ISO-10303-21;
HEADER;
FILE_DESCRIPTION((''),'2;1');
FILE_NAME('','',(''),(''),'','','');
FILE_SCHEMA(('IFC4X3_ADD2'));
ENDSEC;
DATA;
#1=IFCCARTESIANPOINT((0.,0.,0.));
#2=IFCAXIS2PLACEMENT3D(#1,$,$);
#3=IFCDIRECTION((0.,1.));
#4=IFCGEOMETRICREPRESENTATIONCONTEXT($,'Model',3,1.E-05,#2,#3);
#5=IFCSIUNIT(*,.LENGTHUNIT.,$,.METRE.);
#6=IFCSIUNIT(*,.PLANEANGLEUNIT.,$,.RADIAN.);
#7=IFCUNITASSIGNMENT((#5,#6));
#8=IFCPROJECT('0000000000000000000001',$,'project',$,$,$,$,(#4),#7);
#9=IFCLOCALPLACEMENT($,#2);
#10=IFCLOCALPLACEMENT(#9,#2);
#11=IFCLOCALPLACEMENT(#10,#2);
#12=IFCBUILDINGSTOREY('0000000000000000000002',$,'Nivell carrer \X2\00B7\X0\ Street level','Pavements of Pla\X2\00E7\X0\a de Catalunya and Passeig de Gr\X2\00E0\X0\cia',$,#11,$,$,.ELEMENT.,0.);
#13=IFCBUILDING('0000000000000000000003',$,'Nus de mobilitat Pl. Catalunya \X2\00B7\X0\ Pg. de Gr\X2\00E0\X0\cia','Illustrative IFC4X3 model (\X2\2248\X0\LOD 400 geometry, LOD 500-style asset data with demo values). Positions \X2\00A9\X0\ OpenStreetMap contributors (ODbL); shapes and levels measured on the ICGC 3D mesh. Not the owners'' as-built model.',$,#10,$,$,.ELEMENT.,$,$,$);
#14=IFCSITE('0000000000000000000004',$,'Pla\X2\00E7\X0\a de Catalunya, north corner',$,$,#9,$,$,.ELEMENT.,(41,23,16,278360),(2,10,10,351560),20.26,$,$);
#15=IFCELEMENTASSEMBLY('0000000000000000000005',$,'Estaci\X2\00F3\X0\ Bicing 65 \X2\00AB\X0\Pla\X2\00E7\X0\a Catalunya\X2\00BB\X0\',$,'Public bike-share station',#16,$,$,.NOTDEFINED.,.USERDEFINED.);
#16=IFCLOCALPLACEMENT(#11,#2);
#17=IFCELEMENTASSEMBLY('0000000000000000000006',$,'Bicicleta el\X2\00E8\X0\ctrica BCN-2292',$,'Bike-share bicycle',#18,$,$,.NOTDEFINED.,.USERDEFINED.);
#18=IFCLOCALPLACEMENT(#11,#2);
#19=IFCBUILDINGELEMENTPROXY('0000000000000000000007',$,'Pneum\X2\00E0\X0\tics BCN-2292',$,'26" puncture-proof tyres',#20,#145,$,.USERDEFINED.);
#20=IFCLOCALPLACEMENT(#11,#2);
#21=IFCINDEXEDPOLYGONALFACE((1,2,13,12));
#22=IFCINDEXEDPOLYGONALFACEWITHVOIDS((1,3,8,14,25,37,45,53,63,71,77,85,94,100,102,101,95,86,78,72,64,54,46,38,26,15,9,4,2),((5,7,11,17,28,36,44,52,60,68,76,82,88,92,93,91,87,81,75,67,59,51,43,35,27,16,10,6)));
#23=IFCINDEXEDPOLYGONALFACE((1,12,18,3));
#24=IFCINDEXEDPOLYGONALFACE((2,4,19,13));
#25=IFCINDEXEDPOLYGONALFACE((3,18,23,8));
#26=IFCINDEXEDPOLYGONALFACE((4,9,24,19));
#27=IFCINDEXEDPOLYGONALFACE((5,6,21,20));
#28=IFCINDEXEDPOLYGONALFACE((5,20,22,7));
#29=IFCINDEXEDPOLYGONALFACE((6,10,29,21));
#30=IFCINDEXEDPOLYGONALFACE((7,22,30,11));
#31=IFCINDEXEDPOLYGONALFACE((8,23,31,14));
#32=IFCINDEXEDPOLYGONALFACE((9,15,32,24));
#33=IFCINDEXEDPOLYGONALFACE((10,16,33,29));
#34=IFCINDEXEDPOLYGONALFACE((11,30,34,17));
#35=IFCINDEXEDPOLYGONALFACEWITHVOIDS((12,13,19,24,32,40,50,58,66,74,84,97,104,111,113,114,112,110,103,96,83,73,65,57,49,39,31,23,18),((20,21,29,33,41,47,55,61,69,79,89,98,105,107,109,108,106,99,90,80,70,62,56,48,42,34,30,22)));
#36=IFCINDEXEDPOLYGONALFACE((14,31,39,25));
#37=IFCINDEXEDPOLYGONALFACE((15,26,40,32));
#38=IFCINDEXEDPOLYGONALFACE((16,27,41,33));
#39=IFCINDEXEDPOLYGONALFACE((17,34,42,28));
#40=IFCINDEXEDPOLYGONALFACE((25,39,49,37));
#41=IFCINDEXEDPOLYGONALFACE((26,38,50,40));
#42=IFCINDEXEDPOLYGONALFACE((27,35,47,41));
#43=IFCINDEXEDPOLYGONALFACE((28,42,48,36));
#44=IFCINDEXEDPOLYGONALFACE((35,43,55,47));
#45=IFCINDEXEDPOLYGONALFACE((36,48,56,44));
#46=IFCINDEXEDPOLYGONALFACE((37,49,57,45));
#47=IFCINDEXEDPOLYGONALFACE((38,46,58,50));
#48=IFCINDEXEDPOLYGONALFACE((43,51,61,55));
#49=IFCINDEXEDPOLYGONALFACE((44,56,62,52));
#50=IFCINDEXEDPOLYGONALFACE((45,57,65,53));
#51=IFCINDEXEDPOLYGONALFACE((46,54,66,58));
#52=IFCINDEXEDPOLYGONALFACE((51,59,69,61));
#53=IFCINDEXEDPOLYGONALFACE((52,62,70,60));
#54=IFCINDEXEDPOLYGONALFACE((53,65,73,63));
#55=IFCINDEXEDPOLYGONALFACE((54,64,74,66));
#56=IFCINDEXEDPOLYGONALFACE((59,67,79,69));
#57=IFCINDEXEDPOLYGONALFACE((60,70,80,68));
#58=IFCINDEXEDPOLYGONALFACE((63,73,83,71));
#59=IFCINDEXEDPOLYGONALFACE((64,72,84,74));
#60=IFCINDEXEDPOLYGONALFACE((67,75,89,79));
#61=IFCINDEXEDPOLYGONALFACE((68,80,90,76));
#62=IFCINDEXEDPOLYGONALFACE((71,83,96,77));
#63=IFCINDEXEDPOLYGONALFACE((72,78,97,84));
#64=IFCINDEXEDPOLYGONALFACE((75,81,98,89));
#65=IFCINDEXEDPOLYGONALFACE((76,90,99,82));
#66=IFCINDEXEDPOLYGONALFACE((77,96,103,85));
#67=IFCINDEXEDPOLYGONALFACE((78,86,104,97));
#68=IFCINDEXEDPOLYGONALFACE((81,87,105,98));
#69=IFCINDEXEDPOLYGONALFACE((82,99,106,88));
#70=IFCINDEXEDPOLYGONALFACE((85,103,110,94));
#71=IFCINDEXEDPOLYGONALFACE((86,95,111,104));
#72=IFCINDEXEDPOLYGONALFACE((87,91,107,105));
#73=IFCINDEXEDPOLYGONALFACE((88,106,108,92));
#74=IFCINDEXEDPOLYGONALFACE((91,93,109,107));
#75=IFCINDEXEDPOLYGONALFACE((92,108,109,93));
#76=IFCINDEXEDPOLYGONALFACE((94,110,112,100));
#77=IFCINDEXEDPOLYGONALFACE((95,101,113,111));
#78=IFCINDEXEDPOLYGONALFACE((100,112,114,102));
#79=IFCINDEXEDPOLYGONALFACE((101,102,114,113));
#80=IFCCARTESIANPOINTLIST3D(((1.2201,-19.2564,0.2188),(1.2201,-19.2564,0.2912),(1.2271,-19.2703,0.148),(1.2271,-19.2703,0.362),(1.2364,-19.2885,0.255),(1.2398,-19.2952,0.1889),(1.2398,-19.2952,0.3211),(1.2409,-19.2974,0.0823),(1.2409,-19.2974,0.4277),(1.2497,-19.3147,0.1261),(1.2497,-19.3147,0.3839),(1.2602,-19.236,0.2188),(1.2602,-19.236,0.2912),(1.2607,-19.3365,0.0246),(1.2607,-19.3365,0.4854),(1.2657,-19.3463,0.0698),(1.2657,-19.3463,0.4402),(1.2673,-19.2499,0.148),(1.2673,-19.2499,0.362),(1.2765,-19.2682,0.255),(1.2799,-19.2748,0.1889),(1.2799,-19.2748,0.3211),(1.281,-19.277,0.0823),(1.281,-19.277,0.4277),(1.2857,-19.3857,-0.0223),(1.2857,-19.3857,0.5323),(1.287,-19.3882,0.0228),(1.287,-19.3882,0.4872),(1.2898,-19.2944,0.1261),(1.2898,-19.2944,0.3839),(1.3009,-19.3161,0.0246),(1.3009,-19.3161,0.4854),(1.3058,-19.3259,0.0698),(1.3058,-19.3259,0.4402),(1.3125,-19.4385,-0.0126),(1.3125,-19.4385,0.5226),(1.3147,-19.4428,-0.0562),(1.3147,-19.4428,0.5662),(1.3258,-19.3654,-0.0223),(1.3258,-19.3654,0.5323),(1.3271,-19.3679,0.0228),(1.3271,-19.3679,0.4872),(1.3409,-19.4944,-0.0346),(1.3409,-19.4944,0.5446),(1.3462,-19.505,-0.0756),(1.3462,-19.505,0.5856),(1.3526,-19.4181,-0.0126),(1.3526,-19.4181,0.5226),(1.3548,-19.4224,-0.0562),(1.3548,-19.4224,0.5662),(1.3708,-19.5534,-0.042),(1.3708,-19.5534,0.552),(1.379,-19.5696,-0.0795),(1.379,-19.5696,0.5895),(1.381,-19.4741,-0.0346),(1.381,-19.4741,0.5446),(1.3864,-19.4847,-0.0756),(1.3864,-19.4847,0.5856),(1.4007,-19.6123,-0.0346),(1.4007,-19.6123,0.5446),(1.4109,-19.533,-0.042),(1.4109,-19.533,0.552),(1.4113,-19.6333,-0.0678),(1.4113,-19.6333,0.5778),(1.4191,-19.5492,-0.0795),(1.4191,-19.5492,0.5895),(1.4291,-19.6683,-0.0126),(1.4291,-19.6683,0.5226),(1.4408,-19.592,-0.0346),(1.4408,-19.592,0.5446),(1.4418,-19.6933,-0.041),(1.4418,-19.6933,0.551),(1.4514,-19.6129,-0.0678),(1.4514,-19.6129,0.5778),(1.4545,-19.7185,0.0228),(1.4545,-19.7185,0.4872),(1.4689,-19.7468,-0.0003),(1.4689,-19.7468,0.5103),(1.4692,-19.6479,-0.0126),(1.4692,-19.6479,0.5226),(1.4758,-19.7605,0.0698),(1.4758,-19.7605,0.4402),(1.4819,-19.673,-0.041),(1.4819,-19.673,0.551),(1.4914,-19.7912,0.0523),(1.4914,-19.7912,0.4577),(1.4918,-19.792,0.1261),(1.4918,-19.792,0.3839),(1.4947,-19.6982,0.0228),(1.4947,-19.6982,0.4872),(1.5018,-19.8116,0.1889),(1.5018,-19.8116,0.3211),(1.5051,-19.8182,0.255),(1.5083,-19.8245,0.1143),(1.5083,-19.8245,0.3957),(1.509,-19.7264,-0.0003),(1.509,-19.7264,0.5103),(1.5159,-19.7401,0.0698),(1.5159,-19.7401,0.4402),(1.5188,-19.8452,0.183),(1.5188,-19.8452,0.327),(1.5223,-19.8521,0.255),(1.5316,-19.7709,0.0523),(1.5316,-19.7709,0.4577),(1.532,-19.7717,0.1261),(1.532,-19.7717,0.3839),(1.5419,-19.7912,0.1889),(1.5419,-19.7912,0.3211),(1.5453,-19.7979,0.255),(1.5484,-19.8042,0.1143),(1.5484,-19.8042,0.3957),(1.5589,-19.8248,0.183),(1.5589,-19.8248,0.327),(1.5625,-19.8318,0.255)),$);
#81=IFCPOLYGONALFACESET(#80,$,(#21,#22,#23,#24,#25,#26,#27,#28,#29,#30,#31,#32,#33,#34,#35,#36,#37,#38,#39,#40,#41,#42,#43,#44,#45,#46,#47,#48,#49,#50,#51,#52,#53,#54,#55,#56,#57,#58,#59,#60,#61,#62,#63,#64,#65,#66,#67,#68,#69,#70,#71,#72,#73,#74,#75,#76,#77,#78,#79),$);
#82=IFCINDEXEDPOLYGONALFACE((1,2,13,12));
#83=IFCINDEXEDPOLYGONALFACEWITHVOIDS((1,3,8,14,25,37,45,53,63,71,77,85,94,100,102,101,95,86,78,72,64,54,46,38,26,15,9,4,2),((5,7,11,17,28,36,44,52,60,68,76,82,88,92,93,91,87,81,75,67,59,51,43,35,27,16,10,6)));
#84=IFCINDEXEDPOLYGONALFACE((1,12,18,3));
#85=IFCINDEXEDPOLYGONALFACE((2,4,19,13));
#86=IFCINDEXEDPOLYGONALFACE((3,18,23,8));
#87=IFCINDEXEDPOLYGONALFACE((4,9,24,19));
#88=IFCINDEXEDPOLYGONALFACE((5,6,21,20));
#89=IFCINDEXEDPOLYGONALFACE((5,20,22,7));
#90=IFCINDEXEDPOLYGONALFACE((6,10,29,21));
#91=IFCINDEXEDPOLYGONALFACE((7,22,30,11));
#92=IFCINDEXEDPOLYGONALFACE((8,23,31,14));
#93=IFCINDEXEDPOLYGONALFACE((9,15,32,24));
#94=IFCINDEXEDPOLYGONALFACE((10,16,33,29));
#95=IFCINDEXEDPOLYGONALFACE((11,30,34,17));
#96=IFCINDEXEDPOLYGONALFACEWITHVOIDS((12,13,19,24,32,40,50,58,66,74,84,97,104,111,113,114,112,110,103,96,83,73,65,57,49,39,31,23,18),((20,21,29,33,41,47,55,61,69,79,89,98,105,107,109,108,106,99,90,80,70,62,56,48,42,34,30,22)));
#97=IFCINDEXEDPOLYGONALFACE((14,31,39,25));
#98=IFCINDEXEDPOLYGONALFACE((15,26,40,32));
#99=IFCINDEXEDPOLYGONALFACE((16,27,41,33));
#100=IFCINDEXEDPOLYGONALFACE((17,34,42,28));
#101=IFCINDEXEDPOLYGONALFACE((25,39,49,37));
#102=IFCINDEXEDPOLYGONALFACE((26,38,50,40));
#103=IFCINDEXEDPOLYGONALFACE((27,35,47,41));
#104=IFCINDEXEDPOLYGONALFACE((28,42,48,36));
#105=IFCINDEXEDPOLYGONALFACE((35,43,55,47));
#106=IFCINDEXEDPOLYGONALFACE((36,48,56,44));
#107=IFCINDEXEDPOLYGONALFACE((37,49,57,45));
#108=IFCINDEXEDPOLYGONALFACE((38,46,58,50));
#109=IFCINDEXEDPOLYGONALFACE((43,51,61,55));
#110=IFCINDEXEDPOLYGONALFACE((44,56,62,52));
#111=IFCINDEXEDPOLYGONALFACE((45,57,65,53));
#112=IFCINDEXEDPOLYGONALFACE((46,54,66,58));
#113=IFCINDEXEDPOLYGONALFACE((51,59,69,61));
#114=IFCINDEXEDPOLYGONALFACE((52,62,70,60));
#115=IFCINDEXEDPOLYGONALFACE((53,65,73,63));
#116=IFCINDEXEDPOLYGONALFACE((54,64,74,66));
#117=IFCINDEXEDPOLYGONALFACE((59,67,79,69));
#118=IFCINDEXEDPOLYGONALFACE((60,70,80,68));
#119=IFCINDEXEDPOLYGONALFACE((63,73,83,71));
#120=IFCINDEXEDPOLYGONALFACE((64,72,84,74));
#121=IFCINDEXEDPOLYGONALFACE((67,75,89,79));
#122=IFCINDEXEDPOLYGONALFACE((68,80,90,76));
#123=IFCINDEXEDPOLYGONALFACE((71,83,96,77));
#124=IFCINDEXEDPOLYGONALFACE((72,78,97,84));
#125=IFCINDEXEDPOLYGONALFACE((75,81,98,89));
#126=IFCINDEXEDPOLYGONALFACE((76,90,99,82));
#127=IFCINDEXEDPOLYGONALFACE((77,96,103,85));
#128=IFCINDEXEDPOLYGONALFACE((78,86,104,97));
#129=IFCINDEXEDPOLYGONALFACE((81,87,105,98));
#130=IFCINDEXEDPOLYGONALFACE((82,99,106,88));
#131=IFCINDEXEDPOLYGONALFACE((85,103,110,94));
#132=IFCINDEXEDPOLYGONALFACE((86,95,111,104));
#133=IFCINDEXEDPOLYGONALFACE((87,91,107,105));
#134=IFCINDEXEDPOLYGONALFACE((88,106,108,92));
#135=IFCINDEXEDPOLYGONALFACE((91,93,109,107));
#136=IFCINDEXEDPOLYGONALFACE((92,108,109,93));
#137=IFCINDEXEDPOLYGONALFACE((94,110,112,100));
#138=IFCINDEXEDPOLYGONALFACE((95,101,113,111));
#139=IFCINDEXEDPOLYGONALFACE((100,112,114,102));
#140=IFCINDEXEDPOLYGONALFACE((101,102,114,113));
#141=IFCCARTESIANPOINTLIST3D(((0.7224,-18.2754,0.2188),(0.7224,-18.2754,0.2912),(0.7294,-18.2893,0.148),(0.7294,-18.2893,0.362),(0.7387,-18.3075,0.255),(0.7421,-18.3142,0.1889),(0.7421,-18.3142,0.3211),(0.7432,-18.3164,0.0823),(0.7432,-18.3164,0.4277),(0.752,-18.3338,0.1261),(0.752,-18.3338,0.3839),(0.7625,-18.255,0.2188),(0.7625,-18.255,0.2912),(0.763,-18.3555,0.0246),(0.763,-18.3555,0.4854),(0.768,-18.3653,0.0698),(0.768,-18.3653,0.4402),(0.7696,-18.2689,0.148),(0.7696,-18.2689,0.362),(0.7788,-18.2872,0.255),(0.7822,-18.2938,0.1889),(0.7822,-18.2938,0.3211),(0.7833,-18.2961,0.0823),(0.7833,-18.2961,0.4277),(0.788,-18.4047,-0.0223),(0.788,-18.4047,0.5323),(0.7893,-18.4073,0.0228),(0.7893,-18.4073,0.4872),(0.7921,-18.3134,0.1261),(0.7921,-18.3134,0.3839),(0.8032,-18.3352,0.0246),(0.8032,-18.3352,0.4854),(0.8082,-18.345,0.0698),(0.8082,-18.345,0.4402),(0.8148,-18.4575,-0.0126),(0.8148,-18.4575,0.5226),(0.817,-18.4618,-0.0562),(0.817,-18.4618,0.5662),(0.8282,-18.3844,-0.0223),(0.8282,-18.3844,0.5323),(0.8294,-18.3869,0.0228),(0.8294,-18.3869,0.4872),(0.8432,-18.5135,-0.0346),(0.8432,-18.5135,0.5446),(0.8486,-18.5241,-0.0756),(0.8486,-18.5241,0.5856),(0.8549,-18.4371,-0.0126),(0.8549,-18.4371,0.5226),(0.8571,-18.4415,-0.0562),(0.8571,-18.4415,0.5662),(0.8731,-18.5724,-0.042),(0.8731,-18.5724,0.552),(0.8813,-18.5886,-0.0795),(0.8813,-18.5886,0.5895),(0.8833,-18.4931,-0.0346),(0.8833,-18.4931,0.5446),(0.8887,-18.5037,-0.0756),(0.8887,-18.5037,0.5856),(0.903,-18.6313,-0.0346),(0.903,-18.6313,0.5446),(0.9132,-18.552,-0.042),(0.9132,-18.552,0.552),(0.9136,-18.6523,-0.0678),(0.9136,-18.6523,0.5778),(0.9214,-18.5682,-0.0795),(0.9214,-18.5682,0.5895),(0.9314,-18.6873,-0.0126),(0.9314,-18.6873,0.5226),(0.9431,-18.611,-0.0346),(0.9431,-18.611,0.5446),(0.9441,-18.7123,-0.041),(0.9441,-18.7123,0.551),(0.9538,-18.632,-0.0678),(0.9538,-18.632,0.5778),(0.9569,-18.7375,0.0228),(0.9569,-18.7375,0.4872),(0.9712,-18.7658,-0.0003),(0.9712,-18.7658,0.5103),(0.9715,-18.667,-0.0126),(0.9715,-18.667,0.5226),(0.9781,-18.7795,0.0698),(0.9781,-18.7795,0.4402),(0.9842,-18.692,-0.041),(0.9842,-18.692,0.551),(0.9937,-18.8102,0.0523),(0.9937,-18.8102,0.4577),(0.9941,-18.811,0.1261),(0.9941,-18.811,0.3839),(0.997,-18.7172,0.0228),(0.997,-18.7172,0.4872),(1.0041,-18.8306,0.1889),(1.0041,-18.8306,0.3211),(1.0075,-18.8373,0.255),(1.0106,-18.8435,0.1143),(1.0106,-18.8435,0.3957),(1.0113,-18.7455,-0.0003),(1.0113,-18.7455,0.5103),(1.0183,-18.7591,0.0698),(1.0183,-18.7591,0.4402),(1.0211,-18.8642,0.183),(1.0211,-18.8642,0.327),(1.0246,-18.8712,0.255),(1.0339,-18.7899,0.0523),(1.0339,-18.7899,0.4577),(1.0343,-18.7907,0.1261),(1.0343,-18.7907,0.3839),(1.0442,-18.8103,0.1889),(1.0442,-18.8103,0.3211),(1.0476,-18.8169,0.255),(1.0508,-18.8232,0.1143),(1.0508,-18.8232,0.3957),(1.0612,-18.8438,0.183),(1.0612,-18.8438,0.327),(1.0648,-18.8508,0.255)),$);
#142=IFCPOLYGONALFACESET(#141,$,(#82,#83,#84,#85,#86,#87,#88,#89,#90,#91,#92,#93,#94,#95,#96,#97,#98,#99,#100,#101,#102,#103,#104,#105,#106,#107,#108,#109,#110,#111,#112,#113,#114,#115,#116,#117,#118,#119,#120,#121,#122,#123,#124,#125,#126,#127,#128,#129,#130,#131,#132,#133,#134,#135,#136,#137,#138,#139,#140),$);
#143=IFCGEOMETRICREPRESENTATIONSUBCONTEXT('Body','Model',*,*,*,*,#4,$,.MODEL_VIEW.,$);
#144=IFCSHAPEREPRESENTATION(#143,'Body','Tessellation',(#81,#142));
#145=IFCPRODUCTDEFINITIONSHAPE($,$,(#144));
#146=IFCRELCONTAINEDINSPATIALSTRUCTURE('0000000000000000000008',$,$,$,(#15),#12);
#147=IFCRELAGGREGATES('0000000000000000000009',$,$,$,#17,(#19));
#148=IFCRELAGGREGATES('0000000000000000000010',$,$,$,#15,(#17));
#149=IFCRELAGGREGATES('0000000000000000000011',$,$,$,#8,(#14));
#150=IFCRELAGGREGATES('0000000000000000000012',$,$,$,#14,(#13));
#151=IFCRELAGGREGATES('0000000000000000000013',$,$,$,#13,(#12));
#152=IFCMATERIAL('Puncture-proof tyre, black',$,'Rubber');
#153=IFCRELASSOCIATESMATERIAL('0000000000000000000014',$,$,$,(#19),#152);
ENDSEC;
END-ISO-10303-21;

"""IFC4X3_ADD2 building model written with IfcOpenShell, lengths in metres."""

from ifc_helpers import new_model, si_unit, direction, frame, origin, origin_2d_with_axis, place, context, subcontext, project, spatial, hollow_circle, extrude, material, element, aggregate, save


model = new_model("IFC4X3_ADD2")

# Units and contexts
model_context = context("Model", 3, precision=1e-05, world=origin(), true_north=direction((0.0, 1.0)))
body_context = subcontext(model_context, "Body", "Model", "MODEL_VIEW")
ifc_project = project(units=[si_unit("LENGTHUNIT", "METRE"), si_unit("PLANEANGLEUNIT", "RADIAN")], contexts=[model_context])

# Site, building, storey
site_placement = place(None, origin())
site = spatial("IfcSite", under=ifc_project, at=site_placement, Name="Plaça de Catalunya, north corner", CompositionType="ELEMENT", RefLatitude=(41, 23, 16, 278360), RefLongitude=(2, 10, 10, 351560), RefElevation=20.26)
building_placement = place(site_placement, origin())
building = spatial("IfcBuilding", under=site, at=building_placement, Name="Nus de mobilitat Pl. Catalunya · Pg. de Gràcia", Description="Illustrative IFC4X3 model (≈LOD 400 geometry, LOD 500-style asset data with demo values). Positions © OpenStreetMap contributors (ODbL); shapes and levels measured on the ICGC 3D mesh. Not the owners' as-built model.", CompositionType="ELEMENT")
storey_placement = place(building_placement, origin())
storey = spatial("IfcBuildingStorey", under=building, at=storey_placement, Name="Nivell carrer · Street level", Description="Pavements of Plaça de Catalunya and Passeig de Gràcia", CompositionType="ELEMENT", Elevation=0.0)

# Element assemblies, building element proxy
assembly_1_placement = place(building_placement, origin())
assembly_1 = element("IfcElementAssembly", 1, at=assembly_1_placement, inside=storey, Name="Estació Bicing 65 «Plaça Catalunya»", ObjectType="Public bike-share station", AssemblyPlace="NOTDEFINED", PredefinedType="USERDEFINED")
assembly_2_placement = place(building_placement, origin())
assembly_2 = element("IfcElementAssembly", 2, at=assembly_2_placement, Name="Bicicleta elèctrica BCN-2292", ObjectType="Bike-share bicycle", AssemblyPlace="NOTDEFINED", PredefinedType="USERDEFINED")
ifc_material_1 = material(Name="Puncture-proof tyre, black", Category="Rubber")
proxy_1_placement = place(building_placement, origin())
proxy_1 = element("IfcBuildingElementProxy", 3, at=proxy_1_placement, material=ifc_material_1, Name="Pneumàtics BCN-2292", ObjectType="26\" puncture-proof tyres", PredefinedType="USERDEFINED", context=body_context, shape_type="SweptSolid", body=[
    extrude(hollow_circle(Radius=0.335, WallThickness=0.038, at=origin_2d_with_axis()), frame((1.3708, -19.5534, 0.255), z_axis=(0.891798, 0.452435, 0.0), x_axis=(0.452435, -0.891798, 0.0)), (0.0, 0.0, 1.0), 0.045),
    extrude(hollow_circle(Radius=0.335, WallThickness=0.038, at=origin_2d_with_axis()), frame((0.8731, -18.5724, 0.255), z_axis=(0.891798, 0.452435, 0.0), x_axis=(0.452435, -0.891798, 0.0)), (0.0, 0.0, 1.0), 0.045),
])
aggregate(assembly_2, [proxy_1])
aggregate(assembly_1, [assembly_2])

save(model, "model.ifc")
